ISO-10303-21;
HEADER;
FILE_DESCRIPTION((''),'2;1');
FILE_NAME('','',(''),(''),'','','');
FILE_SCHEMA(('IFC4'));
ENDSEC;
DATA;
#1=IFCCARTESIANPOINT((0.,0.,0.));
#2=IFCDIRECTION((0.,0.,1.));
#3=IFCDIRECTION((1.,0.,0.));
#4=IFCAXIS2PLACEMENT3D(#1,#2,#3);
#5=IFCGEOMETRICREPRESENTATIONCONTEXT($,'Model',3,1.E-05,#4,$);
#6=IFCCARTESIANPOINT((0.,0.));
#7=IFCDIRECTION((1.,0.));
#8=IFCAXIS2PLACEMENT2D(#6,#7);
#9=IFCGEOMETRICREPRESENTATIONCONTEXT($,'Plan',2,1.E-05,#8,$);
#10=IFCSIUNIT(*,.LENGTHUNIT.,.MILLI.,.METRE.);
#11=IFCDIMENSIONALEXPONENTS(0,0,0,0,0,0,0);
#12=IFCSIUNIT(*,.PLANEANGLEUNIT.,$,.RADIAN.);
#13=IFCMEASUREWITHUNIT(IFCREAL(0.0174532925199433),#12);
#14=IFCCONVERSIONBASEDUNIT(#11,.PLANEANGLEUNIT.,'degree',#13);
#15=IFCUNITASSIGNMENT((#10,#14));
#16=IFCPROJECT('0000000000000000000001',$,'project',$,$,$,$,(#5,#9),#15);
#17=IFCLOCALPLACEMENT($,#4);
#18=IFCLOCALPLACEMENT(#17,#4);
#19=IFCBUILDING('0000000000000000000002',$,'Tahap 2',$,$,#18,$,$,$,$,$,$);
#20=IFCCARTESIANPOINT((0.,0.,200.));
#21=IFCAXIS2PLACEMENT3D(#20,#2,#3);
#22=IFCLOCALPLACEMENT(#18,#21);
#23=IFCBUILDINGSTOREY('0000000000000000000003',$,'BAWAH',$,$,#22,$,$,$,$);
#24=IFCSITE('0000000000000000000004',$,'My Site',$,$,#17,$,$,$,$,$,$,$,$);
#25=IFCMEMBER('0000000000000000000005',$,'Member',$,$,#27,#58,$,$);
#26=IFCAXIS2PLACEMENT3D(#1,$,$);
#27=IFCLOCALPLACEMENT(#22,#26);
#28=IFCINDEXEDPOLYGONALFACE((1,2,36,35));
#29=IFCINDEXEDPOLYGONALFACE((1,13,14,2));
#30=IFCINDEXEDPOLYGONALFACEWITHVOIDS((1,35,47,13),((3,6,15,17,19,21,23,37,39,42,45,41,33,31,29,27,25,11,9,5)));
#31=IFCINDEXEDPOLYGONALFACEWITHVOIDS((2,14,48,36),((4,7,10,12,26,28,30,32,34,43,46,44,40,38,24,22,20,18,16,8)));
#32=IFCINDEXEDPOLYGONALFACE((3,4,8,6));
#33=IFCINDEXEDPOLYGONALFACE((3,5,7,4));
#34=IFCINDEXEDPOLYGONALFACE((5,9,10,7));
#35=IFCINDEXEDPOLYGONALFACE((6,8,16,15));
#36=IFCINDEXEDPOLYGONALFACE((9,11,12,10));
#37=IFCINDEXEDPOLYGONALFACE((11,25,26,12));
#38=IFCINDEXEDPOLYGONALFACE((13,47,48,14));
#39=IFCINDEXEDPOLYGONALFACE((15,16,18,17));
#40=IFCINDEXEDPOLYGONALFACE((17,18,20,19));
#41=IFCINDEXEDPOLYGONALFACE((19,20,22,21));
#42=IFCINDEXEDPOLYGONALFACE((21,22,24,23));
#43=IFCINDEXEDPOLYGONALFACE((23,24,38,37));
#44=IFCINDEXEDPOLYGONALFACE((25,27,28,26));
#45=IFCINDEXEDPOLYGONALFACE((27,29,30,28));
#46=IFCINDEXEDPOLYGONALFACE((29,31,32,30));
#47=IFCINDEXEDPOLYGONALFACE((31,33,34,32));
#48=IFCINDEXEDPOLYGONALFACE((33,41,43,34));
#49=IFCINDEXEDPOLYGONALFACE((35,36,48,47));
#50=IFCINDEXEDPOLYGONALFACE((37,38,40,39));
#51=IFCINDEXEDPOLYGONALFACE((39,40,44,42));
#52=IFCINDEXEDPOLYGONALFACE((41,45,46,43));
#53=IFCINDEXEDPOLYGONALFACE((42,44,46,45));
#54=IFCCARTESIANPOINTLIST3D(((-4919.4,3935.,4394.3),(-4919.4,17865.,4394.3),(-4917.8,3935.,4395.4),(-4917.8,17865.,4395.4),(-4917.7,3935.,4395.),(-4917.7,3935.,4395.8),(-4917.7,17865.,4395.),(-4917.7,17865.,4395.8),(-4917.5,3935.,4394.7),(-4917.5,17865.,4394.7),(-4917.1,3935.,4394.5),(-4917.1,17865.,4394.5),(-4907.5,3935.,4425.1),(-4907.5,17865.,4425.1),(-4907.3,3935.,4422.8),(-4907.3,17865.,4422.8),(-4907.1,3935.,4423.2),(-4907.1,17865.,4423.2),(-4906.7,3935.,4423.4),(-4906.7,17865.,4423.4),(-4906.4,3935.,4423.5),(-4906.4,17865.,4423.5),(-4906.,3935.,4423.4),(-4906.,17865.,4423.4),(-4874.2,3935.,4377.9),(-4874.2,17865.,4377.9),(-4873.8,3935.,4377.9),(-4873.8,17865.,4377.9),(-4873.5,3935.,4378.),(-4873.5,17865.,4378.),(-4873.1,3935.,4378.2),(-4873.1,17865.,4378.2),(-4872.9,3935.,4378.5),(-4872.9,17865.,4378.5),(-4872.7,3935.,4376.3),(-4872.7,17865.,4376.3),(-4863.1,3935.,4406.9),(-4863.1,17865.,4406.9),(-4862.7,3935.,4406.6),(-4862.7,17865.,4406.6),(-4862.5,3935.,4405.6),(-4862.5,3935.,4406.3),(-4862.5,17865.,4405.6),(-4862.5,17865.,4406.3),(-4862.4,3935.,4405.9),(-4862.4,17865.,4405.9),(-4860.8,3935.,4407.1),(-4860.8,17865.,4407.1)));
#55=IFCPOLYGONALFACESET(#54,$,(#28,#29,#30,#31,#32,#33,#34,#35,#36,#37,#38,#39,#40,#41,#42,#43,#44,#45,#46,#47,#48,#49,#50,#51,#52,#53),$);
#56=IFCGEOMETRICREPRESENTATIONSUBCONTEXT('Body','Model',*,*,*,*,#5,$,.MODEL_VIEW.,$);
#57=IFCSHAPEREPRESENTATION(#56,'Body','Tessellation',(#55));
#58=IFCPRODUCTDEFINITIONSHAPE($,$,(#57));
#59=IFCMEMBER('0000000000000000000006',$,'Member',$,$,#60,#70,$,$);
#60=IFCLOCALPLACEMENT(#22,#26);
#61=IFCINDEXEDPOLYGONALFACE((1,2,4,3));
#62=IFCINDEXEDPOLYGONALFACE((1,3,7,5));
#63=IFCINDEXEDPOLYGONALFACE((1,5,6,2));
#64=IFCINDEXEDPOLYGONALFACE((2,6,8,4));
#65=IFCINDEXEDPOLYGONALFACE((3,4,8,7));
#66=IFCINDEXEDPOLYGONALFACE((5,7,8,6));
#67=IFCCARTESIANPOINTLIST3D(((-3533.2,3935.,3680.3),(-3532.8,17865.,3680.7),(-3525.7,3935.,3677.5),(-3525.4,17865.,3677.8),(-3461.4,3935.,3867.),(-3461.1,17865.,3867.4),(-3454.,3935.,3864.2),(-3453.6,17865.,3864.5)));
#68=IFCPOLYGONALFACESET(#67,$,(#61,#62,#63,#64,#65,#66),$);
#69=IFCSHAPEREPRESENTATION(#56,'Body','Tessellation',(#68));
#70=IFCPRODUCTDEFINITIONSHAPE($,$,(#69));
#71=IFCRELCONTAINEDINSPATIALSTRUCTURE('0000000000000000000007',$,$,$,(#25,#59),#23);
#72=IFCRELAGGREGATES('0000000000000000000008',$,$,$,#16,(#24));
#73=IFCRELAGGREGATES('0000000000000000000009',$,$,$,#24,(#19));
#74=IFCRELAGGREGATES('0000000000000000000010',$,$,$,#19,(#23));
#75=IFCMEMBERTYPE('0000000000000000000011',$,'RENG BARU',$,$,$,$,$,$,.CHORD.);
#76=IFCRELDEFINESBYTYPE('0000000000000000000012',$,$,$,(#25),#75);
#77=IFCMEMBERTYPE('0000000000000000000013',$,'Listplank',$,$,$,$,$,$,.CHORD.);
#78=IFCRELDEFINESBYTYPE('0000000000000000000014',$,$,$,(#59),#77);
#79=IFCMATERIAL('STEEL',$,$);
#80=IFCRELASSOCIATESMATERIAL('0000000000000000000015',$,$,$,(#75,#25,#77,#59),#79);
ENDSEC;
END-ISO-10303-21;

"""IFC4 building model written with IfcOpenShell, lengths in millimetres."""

from ifc_helpers import new_model, entity, si_unit, converted_unit, frame, origin_with_axes, origin_2d_with_axis, place, context, subcontext, project, spatial, rectangle, hollow_rectangle, extrude, material, material_profile, profile_set, profile_usage, type_object, element, save


model = new_model("IFC4")

# Units and contexts
model_context = context("Model", 3, precision=1e-05, world=origin_with_axes())
plan_context = context("Plan", 2, precision=1e-05, world=origin_2d_with_axis())
body_context = subcontext(model_context, "Body", "Model", "MODEL_VIEW")
ifc_project = project(units=[si_unit("LENGTHUNIT", "METRE", prefix="MILLI"), converted_unit("PLANEANGLEUNIT", "degree", entity("IfcReal", 0.0174532925199433), si_unit("PLANEANGLEUNIT", "RADIAN"), dimensions=[0, 0, 0, 0, 0, 0, 0])], contexts=[model_context, plan_context])

# Site, building, storey
site_placement = place(None, origin_with_axes())
site = spatial("IfcSite", under=ifc_project, at=site_placement, Name="My Site")
building_placement = place(site_placement, origin_with_axes())
building = spatial("IfcBuilding", under=site, at=building_placement, Name="Tahap 2")
storey_placement = place(building_placement, frame((0.0, 0.0, 200.0), z_axis=(0.0, 0.0, 1.0), x_axis=(1.0, 0.0, 0.0)))
storey = spatial("IfcBuildingStorey", under=building, at=storey_placement, Name="BAWAH")

# Shared definitions
ifc_material_1 = material(Name="STEEL")

# Members
ifc_material_profile_1 = material_profile(ifc_material_1, hollow_rectangle(XDim=50.0, YDim=33.0, WallThickness=1.0, InnerFilletRadius=1.0, OuterFilletRadius=0.0, kind="CURVE"))
ifc_profile_set_1 = profile_set([ifc_material_profile_1])
member_type_1 = type_object("IfcMemberType", Name="RENG BARU", PredefinedType="CHORD", material=ifc_profile_set_1)
ifc_profile_usage_1 = profile_usage(ifc_profile_set_1, cardinal=3)
member_1_placement = place(storey_placement, frame((-4872.7, 3935.0, 4376.3), z_axis=(0.0, 1.0, 0.0), x_axis=(-0.932954, 0.0, 0.359997)))
element("IfcMember", 1, at=member_1_placement, inside=storey, type_object=member_type_1, material=ifc_profile_usage_1, Name="Member", context=body_context, shape_type="SweptSolid", body=[
    extrude(hollow_rectangle(XDim=50.0, YDim=33.0, WallThickness=1.0, InnerFilletRadius=1.0, OuterFilletRadius=0.0, kind="CURVE"), frame((25.0, 16.5, 0.0), z_axis=(0.0, 0.0, 1.0), x_axis=(1.0, 0.0, 0.0)), (0.0, 0.0, 1.0), 13930.0),
])
ifc_material_profile_2 = material_profile(ifc_material_1, rectangle(XDim=8.0, YDim=200.0, kind="CURVE"))
ifc_profile_set_2 = profile_set([ifc_material_profile_2])
ifc_profile_usage_2 = profile_usage(ifc_profile_set_2, cardinal=7)
member_type_2 = type_object("IfcMemberType", Name="Listplank", PredefinedType="CHORD", material=ifc_profile_set_2)
member_2_placement = place(storey_placement, frame((-3461.4, 3935.0, 3867.0), z_axis=(0.000023, 1.0, 0.000026), x_axis=(-0.933489, 0.000012, 0.358606)))
element("IfcMember", 2, at=member_2_placement, inside=storey, type_object=member_type_2, material=ifc_profile_usage_2, Name="Member", context=body_context, shape_type="SweptSolid", body=[
    extrude(rectangle(XDim=8.0, YDim=200.0, kind="CURVE"), frame((-4.0, -100.0, 0.0), z_axis=(0.0, 0.0, 1.0), x_axis=(1.0, 0.0, 0.0)), (0.0, 0.0, 1.0), 13930.0),
])

save(model, "model.ifc")
